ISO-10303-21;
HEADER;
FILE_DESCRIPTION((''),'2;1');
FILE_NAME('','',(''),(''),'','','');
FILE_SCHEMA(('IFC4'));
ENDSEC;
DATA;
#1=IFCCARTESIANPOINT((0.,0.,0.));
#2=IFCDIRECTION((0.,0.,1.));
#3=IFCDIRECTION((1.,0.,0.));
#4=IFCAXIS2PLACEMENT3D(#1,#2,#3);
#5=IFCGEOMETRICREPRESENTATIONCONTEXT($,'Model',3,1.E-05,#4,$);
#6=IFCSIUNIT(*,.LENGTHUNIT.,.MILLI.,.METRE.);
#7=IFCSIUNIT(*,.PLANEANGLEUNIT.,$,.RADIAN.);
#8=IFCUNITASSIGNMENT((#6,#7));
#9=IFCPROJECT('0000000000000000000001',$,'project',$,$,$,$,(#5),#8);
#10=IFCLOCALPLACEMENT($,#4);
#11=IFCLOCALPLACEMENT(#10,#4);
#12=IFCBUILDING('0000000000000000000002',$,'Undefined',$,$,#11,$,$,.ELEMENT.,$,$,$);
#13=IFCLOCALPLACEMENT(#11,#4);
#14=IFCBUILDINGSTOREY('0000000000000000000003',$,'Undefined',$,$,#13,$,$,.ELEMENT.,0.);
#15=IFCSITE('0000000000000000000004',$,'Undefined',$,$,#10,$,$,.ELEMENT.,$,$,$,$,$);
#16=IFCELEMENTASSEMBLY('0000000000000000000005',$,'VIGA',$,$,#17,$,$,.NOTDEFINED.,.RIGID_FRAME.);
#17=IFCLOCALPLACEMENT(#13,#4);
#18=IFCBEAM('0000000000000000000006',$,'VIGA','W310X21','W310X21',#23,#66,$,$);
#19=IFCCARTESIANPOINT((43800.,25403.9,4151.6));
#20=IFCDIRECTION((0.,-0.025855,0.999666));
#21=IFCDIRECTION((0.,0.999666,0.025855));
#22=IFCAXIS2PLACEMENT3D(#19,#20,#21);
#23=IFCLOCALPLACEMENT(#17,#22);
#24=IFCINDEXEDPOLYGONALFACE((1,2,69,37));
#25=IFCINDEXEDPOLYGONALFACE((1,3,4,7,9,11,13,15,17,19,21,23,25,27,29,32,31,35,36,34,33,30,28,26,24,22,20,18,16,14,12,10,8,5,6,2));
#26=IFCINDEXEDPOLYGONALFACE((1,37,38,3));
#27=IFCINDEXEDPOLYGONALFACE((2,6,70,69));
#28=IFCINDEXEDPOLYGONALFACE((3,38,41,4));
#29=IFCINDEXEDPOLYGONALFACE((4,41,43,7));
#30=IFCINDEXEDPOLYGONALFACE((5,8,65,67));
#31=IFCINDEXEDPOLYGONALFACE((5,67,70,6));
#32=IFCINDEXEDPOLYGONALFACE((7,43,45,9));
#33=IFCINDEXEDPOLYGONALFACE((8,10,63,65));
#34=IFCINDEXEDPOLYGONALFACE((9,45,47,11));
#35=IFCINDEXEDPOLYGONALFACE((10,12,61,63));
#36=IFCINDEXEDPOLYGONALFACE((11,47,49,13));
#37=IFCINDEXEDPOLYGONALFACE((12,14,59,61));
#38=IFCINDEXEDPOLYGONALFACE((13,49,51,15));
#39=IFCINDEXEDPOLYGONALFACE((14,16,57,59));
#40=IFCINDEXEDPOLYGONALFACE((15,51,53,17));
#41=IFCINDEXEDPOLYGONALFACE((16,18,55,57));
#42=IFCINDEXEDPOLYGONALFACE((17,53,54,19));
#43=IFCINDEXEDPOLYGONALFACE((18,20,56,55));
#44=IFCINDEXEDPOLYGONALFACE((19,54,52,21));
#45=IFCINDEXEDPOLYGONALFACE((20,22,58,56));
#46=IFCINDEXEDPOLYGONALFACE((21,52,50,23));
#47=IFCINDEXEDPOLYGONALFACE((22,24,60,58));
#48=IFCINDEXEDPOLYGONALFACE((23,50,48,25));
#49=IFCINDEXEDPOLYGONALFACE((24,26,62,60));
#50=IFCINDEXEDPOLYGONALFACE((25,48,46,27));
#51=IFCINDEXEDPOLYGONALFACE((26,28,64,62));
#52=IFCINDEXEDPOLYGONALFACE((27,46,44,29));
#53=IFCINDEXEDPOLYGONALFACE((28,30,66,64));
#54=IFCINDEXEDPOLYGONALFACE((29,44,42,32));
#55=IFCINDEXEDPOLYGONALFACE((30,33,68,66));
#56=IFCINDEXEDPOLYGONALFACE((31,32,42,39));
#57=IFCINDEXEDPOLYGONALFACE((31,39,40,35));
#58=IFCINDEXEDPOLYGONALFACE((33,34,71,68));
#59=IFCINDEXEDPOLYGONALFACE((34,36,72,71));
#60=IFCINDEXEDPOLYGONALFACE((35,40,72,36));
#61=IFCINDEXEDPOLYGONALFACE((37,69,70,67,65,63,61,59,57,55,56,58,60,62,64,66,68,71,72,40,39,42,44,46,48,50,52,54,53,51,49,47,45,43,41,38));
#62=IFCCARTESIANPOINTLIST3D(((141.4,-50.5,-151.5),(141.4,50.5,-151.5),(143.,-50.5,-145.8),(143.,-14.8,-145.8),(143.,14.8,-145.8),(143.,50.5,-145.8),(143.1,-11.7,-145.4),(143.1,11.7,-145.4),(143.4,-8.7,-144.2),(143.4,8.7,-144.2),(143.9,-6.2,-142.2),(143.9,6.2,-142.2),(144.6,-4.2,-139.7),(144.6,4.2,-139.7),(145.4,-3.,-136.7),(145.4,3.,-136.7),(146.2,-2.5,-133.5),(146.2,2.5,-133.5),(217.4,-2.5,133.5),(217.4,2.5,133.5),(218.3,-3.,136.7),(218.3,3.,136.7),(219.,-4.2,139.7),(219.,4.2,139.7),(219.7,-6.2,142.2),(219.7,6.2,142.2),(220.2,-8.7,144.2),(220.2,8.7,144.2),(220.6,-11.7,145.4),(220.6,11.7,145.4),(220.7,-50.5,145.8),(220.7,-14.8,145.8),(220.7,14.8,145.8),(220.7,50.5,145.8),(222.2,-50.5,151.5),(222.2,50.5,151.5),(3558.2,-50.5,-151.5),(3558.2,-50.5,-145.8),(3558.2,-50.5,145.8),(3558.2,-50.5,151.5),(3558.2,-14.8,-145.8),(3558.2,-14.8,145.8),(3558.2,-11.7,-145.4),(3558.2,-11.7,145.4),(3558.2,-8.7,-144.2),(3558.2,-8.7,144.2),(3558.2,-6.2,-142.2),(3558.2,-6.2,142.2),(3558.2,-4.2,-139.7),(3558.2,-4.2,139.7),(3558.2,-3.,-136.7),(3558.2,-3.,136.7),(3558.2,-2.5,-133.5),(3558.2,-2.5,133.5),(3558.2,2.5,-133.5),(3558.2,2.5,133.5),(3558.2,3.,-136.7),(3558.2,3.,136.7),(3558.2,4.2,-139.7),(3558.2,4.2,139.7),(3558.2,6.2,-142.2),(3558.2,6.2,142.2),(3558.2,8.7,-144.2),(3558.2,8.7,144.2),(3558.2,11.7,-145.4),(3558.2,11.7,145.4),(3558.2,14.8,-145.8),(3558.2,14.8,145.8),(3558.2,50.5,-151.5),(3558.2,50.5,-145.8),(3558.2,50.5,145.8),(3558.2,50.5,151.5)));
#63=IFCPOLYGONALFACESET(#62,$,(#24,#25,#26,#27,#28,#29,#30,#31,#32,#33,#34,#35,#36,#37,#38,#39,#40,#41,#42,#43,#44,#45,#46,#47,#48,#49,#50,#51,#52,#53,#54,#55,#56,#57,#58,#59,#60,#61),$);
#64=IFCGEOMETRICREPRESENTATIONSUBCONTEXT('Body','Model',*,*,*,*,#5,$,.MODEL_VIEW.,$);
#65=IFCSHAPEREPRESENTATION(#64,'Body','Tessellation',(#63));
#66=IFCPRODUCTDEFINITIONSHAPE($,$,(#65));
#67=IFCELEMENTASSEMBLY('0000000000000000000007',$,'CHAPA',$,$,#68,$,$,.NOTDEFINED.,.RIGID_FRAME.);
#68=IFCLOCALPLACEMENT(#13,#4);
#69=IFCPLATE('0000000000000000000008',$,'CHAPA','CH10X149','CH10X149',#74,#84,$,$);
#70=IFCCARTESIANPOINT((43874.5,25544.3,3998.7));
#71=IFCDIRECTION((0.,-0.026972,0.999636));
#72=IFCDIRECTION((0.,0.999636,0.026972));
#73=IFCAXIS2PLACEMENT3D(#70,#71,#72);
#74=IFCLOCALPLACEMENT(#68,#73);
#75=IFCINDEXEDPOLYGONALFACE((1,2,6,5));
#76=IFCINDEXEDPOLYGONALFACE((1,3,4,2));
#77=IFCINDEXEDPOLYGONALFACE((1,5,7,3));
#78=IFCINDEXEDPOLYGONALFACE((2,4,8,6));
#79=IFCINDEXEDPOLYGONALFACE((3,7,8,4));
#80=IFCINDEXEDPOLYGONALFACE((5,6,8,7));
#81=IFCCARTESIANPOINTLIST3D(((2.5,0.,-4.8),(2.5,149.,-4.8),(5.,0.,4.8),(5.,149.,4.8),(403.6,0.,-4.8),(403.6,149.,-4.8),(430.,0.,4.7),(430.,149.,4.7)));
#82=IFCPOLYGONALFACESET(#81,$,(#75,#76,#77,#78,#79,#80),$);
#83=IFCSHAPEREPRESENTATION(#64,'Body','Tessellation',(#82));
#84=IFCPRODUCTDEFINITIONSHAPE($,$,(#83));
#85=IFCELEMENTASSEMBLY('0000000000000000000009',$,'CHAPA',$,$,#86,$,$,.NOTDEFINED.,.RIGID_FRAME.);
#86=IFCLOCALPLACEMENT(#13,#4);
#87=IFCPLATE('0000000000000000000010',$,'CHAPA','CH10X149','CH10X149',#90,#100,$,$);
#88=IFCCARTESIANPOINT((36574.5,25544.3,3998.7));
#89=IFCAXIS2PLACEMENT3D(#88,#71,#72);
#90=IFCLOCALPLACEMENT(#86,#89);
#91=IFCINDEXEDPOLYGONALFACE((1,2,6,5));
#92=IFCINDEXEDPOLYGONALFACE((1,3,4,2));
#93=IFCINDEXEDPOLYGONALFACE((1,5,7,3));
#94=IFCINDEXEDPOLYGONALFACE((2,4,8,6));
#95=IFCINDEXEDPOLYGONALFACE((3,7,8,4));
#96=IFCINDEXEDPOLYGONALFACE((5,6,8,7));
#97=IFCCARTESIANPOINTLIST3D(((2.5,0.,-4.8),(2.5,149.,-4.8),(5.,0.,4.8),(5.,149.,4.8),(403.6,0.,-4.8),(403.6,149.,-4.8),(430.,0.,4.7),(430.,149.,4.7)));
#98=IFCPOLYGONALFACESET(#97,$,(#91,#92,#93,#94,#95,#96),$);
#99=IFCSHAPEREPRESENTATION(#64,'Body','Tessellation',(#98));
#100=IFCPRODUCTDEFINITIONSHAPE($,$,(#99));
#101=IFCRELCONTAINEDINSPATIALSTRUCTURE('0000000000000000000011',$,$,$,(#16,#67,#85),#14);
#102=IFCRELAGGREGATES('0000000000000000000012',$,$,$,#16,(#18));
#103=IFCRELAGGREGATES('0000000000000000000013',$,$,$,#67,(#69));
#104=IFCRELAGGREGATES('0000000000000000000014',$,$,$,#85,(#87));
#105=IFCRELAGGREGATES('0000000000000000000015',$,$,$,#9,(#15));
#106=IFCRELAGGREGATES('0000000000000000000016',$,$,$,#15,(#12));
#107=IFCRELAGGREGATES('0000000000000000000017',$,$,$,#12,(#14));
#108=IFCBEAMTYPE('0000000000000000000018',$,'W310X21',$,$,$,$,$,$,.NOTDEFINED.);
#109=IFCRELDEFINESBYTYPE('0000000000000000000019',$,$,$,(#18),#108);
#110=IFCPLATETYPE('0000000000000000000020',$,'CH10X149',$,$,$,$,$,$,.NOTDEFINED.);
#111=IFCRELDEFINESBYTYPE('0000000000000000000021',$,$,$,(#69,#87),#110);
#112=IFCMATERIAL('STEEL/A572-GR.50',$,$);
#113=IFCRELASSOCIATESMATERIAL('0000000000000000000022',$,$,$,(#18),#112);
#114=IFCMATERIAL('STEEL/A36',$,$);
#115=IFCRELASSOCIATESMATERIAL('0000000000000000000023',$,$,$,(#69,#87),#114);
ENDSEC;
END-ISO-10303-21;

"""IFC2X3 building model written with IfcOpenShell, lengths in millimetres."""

from ifc_helpers import new_model, si_unit, frame, origin_with_axes, origin_2d_with_axis, place, context, subcontext, project, spatial, polyline, i_section, outline, extrude, clip, halfspace, material, type_object, element, aggregate, save


model = new_model("IFC2X3")

# Units and contexts
model_context = context("Model", 3, precision=1e-05, world=origin_with_axes())
body_context = subcontext(model_context, "Body", "Model", "MODEL_VIEW")
ifc_project = project(units=[si_unit("LENGTHUNIT", "METRE", prefix="MILLI"), si_unit("PLANEANGLEUNIT", "RADIAN")], contexts=[model_context])

# Site, building, storey
site_placement = place(None, origin_with_axes())
site = spatial("IfcSite", under=ifc_project, at=site_placement, Name="Undefined", CompositionType="ELEMENT")
building_placement = place(site_placement, origin_with_axes())
building = spatial("IfcBuilding", under=site, at=building_placement, Name="Undefined", CompositionType="ELEMENT")
storey_placement = place(building_placement, origin_with_axes())
storey = spatial("IfcBuildingStorey", under=building, at=storey_placement, Name="Undefined", CompositionType="ELEMENT", Elevation=0.0)

# Element assembly, beam
ifc_material_1 = material(Name="STEEL/A572-GR.50")
assembly_1_placement = place(storey_placement, origin_with_axes())
assembly_1 = element("IfcElementAssembly", 1, at=assembly_1_placement, inside=storey, Name="VIGA", AssemblyPlace="NOTDEFINED", PredefinedType="RIGID_FRAME")
beam_type_1 = type_object("IfcBeamType", Name="W310X21", PredefinedType="NOTDEFINED")
beam_1_placement = place(assembly_1_placement, frame((43800.0, 25403.9, 4151.6), z_axis=(0.0, -0.025855, 0.999666), x_axis=(0.0, 0.999666, 0.025855)))
beam_1 = element("IfcBeam", 2, at=beam_1_placement, type_object=beam_type_1, material=ifc_material_1, Name="VIGA", Description="W310X21", ObjectType="W310X21", context=body_context, shape_type="Clipping", body=[
    clip(extrude(i_section(OverallWidth=101.0, OverallDepth=303.0, WebThickness=5.1, FlangeThickness=5.7, FilletRadius=12.3, at=origin_2d_with_axis()), frame((3558.2, 0.0, 0.0), z_axis=(-1.0, 0.0, 0.0), x_axis=(0.0, -1.0, 0.0)), (0.0, 0.0, 1.0), 3558.2), halfspace(frame((141.4, -50.5, -151.7), z_axis=(-0.966259, 0.0, 0.257573), x_axis=(0.0, 1.0, 0.0)), False)),
])
aggregate(assembly_1, [beam_1])

# Shared definitions
ifc_material_2 = material(Name="STEEL/A36")

# Element assemblies, plates
plate_type_1 = type_object("IfcPlateType", Name="CH10X149", PredefinedType="NOTDEFINED")
assembly_2_placement = place(storey_placement, origin_with_axes())
assembly_2 = element("IfcElementAssembly", 3, at=assembly_2_placement, inside=storey, Name="CHAPA", AssemblyPlace="NOTDEFINED", PredefinedType="RIGID_FRAME")
plate_1_placement = place(assembly_2_placement, frame((43874.5, 25544.3, 3998.7), z_axis=(0.0, -0.026972, 0.999636), x_axis=(0.0, 0.999636, 0.026972)))
plate_1 = element("IfcPlate", 4, at=plate_1_placement, type_object=plate_type_1, material=ifc_material_2, Name="CHAPA", Description="CH10X149", ObjectType="CH10X149", context=body_context, shape_type="Clipping", body=[
    clip(clip(extrude(outline(polyline([(0.0, 0.0), (430.0, 0.0), (430.0, 149.0), (0.0, 149.0), (0.0, 0.0)])), frame((0.0, 0.0, -4.8), z_axis=(0.0, 0.0, 1.0), x_axis=(1.0, 0.0, 0.0)), (0.0, 0.0, 1.0), 9.5), halfspace(frame((403.6, -500.0, -4.8), z_axis=(0.33881, 0.0, -0.940855), x_axis=(0.940855, 0.0, 0.33881)), False)), halfspace(frame((5.0, -500.0, 4.7), z_axis=(-0.965989, 0.0, 0.258583), x_axis=(-0.258583, 0.0, -0.965989)), False)),
])
aggregate(assembly_2, [plate_1])
assembly_3_placement = place(storey_placement, origin_with_axes())
assembly_3 = element("IfcElementAssembly", 5, at=assembly_3_placement, inside=storey, Name="CHAPA", AssemblyPlace="NOTDEFINED", PredefinedType="RIGID_FRAME")
plate_2_placement = place(assembly_3_placement, frame((36574.5, 25544.3, 3998.7), z_axis=(0.0, -0.026972, 0.999636), x_axis=(0.0, 0.999636, 0.026972)))
plate_2 = element("IfcPlate", 6, at=plate_2_placement, type_object=plate_type_1, material=ifc_material_2, Name="CHAPA", Description="CH10X149", ObjectType="CH10X149", context=body_context, shape_type="Clipping", body=[
    clip(clip(extrude(outline(polyline([(0.0, 0.0), (430.0, 0.0), (430.0, 149.0), (0.0, 149.0), (0.0, 0.0)])), frame((0.0, 0.0, -4.8), z_axis=(0.0, 0.0, 1.0), x_axis=(1.0, 0.0, 0.0)), (0.0, 0.0, 1.0), 9.5), halfspace(frame((403.6, -500.0, -4.8), z_axis=(0.33881, 0.0, -0.940855), x_axis=(0.940855, 0.0, 0.33881)), False)), halfspace(frame((5.0, -500.0, 4.7), z_axis=(-0.965989, 0.0, 0.258583), x_axis=(-0.258583, 0.0, -0.965989)), False)),
])
aggregate(assembly_3, [plate_2])

save(model, "model.ifc")
